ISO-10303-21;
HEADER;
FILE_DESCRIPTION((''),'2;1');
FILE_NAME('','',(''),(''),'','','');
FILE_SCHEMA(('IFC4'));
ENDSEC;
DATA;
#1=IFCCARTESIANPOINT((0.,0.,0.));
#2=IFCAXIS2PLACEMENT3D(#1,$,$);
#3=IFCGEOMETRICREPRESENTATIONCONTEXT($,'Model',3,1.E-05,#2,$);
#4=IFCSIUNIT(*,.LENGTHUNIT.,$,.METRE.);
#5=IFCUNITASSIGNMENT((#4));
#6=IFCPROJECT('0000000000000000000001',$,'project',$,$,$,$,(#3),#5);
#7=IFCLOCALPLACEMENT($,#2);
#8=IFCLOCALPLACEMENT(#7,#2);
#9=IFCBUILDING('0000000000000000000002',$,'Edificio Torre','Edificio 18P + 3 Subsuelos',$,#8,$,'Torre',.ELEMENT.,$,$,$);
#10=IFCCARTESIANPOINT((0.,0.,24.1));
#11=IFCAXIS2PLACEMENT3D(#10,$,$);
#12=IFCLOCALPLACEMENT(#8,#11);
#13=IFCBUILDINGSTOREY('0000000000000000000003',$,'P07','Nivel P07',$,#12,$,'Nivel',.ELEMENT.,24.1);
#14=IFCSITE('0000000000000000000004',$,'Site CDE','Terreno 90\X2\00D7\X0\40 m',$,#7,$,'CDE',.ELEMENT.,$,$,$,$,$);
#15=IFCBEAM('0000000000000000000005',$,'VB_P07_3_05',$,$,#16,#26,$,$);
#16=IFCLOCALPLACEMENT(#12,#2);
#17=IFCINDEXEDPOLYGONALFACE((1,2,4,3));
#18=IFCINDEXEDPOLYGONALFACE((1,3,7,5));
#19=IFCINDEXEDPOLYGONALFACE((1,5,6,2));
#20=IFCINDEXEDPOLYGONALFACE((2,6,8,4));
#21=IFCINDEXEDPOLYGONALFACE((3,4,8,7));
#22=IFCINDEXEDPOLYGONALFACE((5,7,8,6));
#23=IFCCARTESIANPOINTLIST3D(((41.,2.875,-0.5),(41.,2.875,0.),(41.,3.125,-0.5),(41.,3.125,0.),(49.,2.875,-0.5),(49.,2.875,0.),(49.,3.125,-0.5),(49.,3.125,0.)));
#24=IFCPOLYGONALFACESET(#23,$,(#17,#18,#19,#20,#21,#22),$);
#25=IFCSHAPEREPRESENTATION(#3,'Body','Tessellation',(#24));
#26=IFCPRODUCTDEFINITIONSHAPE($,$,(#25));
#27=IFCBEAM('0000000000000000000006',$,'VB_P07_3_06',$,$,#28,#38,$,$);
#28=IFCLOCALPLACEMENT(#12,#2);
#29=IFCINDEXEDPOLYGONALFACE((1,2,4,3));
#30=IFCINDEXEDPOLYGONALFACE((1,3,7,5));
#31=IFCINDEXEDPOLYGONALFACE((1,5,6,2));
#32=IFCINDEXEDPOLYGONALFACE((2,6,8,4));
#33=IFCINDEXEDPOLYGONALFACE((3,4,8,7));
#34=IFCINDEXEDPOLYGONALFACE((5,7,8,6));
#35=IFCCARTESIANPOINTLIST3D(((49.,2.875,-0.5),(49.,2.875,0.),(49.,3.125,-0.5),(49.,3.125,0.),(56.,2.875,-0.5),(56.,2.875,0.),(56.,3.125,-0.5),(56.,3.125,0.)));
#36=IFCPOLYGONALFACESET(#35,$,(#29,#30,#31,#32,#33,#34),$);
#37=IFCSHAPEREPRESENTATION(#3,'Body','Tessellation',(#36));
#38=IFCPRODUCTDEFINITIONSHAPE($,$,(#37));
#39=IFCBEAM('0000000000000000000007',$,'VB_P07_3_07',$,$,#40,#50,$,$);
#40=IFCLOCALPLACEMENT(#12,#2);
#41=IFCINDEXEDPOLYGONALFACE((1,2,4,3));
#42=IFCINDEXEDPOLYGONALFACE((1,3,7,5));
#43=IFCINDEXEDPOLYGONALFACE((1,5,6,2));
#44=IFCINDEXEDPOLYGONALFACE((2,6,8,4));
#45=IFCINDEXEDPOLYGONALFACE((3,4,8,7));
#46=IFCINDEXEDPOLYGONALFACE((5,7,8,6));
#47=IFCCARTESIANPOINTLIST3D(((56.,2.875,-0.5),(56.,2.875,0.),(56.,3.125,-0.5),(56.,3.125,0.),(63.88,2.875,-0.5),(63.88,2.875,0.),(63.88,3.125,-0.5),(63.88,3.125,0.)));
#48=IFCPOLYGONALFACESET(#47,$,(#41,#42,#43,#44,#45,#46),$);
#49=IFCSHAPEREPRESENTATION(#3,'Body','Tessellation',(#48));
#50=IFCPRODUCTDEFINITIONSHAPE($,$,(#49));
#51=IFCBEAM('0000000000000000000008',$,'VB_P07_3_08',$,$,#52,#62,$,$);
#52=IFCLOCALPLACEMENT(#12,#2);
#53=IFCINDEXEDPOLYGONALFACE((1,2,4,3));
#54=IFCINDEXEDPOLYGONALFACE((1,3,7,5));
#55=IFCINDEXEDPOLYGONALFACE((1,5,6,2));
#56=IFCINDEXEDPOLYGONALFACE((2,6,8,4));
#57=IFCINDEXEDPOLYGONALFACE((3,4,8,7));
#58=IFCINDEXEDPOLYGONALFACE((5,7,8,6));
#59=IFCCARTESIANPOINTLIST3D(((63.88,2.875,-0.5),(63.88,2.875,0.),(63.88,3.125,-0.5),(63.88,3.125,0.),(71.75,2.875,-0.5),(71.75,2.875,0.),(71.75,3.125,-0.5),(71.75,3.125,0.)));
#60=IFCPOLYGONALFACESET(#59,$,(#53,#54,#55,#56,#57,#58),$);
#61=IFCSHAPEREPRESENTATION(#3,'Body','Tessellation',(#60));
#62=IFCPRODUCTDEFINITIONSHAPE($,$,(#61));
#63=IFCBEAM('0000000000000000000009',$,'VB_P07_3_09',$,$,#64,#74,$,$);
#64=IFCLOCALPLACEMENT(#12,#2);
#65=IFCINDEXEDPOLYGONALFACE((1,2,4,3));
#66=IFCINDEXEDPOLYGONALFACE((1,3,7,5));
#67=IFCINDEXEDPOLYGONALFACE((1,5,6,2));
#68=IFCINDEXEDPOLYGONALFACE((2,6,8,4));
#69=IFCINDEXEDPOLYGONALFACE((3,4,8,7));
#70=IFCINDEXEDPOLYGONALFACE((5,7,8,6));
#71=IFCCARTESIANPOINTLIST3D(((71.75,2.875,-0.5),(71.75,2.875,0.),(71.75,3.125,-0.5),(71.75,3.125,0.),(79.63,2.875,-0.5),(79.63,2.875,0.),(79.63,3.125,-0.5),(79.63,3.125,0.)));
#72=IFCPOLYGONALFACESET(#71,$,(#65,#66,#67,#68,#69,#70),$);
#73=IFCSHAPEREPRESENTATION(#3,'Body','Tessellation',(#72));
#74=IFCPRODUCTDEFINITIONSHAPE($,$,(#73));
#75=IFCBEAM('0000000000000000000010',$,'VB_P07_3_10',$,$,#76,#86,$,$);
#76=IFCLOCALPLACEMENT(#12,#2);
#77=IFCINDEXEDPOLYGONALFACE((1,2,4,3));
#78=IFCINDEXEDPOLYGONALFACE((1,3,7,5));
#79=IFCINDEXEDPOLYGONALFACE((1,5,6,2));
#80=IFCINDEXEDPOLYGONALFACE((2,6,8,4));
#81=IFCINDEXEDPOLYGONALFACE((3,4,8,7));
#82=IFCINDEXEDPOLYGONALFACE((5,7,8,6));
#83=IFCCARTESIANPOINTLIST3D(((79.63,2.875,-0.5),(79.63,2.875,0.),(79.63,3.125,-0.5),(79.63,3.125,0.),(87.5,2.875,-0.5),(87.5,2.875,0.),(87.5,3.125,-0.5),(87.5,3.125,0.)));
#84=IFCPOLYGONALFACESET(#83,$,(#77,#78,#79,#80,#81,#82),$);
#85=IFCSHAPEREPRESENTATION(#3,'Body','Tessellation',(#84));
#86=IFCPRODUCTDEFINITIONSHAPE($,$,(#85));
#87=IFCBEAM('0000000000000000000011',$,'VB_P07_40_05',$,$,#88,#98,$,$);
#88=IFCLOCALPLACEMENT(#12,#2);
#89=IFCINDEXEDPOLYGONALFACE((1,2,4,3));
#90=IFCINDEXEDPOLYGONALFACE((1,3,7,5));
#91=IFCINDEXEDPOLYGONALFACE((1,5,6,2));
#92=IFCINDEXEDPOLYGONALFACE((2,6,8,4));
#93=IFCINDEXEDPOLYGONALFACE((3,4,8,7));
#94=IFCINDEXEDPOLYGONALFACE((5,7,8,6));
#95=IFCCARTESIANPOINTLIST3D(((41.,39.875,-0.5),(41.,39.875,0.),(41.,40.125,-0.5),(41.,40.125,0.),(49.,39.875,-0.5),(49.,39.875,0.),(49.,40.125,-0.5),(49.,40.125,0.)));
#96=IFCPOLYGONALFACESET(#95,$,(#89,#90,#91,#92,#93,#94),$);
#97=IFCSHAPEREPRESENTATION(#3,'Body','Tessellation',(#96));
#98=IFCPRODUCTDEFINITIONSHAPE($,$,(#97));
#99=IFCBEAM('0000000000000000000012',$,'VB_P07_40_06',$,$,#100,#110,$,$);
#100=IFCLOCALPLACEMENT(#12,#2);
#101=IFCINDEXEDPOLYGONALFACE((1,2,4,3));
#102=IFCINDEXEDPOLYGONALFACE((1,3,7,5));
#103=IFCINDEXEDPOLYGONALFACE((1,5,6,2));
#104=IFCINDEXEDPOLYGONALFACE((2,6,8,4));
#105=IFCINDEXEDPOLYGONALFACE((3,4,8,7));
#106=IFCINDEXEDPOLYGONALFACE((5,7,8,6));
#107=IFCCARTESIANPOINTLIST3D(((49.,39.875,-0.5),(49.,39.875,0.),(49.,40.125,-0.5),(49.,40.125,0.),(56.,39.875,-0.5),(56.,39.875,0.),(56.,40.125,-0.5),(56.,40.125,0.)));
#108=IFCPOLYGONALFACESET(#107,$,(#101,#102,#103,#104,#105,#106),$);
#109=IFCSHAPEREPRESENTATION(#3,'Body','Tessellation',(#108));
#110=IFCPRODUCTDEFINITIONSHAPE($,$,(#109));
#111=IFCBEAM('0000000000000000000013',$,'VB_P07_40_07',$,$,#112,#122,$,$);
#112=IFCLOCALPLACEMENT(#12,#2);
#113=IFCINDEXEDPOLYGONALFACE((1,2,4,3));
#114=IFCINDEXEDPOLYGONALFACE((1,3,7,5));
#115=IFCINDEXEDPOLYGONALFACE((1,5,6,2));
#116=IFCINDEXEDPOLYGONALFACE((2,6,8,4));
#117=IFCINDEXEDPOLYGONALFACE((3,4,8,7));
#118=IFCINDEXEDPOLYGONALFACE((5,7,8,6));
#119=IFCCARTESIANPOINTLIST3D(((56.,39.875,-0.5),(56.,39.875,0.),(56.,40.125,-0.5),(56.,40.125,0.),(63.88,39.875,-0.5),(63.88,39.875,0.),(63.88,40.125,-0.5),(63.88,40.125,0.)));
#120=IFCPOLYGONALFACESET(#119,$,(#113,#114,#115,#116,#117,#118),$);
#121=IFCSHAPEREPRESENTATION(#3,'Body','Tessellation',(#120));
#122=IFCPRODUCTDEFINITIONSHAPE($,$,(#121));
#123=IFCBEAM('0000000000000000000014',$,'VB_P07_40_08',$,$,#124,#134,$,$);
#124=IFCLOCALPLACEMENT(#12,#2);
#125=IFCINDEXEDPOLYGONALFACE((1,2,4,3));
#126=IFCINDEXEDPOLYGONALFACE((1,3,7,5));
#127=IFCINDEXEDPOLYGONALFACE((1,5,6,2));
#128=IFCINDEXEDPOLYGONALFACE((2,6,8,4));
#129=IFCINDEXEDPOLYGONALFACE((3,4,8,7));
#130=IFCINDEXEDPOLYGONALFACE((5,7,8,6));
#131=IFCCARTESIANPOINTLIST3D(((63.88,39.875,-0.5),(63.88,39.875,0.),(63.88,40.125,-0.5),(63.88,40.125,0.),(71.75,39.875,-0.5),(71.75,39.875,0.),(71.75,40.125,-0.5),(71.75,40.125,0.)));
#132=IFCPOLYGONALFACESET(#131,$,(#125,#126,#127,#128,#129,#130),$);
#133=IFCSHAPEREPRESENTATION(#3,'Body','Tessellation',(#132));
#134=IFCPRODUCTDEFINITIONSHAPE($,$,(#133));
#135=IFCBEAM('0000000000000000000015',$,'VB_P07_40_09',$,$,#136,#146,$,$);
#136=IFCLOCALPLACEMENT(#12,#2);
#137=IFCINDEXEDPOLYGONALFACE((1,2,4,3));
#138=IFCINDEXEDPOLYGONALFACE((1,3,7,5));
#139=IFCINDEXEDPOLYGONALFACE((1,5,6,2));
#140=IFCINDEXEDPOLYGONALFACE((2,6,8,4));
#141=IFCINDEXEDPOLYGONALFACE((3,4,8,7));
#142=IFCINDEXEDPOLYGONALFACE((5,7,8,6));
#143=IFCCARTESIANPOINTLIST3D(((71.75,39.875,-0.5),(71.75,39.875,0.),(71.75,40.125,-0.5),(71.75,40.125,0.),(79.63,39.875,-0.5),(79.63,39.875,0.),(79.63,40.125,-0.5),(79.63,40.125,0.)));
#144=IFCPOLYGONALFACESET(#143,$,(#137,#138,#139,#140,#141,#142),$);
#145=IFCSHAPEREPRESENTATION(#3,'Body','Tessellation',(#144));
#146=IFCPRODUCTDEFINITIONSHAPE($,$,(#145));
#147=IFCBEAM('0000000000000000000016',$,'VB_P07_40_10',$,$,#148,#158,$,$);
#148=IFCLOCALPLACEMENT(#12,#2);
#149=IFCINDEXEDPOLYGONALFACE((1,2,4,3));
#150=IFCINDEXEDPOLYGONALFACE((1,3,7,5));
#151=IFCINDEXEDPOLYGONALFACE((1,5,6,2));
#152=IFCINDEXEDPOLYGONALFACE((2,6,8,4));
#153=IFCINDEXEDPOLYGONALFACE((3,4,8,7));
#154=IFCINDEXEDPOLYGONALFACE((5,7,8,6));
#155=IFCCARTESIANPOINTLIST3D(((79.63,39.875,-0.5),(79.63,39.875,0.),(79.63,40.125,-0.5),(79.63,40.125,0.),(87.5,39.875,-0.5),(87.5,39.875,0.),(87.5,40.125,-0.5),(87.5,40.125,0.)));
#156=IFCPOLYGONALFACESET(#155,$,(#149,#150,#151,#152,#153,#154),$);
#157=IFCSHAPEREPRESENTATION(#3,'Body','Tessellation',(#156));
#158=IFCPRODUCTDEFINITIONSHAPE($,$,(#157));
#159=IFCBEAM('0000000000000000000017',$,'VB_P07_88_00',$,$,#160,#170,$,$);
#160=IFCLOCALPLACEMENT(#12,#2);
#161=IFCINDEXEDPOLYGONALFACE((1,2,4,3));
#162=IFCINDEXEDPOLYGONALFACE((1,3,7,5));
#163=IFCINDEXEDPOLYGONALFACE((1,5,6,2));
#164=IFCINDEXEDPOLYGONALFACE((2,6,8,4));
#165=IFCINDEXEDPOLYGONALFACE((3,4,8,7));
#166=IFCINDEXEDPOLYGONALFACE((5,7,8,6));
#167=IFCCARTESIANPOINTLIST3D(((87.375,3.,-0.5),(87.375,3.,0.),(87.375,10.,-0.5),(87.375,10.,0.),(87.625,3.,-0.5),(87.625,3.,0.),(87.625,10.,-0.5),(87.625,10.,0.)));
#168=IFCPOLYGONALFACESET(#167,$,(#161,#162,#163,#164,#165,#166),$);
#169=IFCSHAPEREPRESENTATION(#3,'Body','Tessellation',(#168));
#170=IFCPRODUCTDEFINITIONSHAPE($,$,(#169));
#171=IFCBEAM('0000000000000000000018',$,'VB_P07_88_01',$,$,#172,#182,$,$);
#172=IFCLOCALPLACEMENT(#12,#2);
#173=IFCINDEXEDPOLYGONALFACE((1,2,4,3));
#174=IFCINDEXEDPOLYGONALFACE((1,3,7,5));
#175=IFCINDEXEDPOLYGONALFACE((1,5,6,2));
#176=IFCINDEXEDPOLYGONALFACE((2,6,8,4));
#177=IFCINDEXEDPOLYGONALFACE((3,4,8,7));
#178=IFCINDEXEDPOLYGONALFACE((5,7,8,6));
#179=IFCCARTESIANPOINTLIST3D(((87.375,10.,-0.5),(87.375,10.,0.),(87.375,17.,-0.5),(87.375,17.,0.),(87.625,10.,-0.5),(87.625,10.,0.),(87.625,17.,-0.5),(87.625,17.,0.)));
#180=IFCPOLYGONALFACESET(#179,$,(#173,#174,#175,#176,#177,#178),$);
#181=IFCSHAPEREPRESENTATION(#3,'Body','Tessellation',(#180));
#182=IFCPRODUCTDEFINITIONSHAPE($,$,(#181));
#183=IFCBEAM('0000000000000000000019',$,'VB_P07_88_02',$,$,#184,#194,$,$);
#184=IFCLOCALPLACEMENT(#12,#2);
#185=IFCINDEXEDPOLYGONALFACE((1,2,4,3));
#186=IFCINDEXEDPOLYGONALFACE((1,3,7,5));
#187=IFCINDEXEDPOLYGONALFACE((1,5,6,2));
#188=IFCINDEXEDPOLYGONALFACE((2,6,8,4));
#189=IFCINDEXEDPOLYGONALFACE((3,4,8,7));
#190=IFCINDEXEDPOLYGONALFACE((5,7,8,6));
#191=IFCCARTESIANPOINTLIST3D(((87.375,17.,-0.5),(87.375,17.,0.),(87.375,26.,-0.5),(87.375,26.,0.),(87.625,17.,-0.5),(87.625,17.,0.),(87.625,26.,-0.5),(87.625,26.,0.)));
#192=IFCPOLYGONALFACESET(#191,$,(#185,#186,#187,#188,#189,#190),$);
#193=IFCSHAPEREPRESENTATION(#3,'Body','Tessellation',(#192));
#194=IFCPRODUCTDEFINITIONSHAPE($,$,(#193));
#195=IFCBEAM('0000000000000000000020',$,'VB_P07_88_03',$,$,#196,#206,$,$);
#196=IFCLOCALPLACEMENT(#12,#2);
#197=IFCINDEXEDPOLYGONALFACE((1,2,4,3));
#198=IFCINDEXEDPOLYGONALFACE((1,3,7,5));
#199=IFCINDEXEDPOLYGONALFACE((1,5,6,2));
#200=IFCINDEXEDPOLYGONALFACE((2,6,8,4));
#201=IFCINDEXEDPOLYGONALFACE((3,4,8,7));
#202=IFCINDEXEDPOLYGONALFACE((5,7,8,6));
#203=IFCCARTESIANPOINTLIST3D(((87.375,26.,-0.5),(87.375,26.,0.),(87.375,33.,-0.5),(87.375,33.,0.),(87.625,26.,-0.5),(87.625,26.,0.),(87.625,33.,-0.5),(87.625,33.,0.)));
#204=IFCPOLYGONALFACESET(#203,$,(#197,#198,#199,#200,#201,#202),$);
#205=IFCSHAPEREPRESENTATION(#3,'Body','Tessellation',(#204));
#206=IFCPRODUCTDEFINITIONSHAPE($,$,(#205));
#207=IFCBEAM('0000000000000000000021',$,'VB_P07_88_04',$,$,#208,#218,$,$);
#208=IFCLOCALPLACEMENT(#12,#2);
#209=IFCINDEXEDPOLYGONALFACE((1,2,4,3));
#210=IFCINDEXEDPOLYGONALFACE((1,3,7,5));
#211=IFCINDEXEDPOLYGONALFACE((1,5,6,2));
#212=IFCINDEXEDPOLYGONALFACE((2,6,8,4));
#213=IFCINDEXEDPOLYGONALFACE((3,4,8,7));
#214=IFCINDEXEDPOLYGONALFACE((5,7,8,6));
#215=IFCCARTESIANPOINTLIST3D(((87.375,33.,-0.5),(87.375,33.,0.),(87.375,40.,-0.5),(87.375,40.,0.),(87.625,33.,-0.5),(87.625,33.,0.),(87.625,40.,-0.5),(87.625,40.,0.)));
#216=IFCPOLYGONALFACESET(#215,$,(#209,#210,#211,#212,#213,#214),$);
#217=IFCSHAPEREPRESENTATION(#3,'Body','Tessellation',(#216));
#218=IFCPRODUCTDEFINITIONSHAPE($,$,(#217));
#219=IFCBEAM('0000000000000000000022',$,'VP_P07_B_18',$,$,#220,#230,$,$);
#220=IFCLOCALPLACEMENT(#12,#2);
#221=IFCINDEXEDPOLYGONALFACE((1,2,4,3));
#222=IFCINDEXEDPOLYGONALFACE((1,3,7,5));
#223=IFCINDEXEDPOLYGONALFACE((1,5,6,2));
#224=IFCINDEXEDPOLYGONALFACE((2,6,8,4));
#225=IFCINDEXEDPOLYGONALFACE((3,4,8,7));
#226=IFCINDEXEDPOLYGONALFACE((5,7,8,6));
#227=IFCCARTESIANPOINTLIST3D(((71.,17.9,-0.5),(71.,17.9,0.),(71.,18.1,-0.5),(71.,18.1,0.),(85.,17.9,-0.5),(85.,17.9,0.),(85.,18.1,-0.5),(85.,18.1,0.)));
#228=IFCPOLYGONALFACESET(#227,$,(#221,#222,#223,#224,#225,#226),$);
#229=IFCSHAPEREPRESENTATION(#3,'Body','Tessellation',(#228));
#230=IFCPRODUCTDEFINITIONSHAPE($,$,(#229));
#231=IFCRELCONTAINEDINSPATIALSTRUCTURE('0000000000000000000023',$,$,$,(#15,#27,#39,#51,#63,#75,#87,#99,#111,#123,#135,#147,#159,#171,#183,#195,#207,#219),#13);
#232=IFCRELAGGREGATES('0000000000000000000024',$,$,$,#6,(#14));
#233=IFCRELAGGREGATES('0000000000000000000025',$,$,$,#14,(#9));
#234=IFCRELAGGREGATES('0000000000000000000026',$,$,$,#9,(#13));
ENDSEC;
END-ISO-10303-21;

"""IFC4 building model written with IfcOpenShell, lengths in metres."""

from ifc_helpers import new_model, si_unit, frame, origin, origin_2d, place, context, project, spatial, rectangle, extrude, element, save


model = new_model("IFC4")

# Units and contexts
model_context = context("Model", 3, precision=1e-05, world=origin())
ifc_project = project(units=[si_unit("LENGTHUNIT", "METRE")], contexts=[model_context])

# Site, building, storey
site_placement = place(None, origin())
site = spatial("IfcSite", under=ifc_project, at=site_placement, Name="Site CDE", Description="Terreno 90×40 m", LongName="CDE", CompositionType="ELEMENT")
building_placement = place(site_placement, origin())
building = spatial("IfcBuilding", under=site, at=building_placement, Name="Edificio Torre", Description="Edificio 18P + 3 Subsuelos", LongName="Torre", CompositionType="ELEMENT")
storey_placement = place(building_placement, frame((0.0, 0.0, 24.1)))
storey = spatial("IfcBuildingStorey", under=building, at=storey_placement, Name="P07", Description="Nivel P07", LongName="Nivel", CompositionType="ELEMENT", Elevation=24.1)

# Beams
beam_1_placement = place(storey_placement, frame((45.0, 3.0, -0.5)))
element("IfcBeam", 1, at=beam_1_placement, inside=storey, Name="VB_P07_3_05", context=model_context, shape_type="SweptSolid", body=[
    extrude(rectangle(XDim=8.0, YDim=0.25, at=origin_2d()), origin(), (0.0, 0.0, 1.0), 0.5),
])
beam_2_placement = place(storey_placement, frame((52.5, 3.0, -0.5)))
element("IfcBeam", 2, at=beam_2_placement, inside=storey, Name="VB_P07_3_06", context=model_context, shape_type="SweptSolid", body=[
    extrude(rectangle(XDim=7.0, YDim=0.25, at=origin_2d()), origin(), (0.0, 0.0, 1.0), 0.5),
])
beam_3_placement = place(storey_placement, frame((59.94, 3.0, -0.5)))
element("IfcBeam", 3, at=beam_3_placement, inside=storey, Name="VB_P07_3_07", context=model_context, shape_type="SweptSolid", body=[
    extrude(rectangle(XDim=7.88, YDim=0.25, at=origin_2d()), origin(), (0.0, 0.0, 1.0), 0.5),
])
beam_4_placement = place(storey_placement, frame((67.815, 3.0, -0.5)))
element("IfcBeam", 4, at=beam_4_placement, inside=storey, Name="VB_P07_3_08", context=model_context, shape_type="SweptSolid", body=[
    extrude(rectangle(XDim=7.87, YDim=0.25, at=origin_2d()), origin(), (0.0, 0.0, 1.0), 0.5),
])
beam_5_placement = place(storey_placement, frame((75.69, 3.0, -0.5)))
element("IfcBeam", 5, at=beam_5_placement, inside=storey, Name="VB_P07_3_09", context=model_context, shape_type="SweptSolid", body=[
    extrude(rectangle(XDim=7.88, YDim=0.25, at=origin_2d()), origin(), (0.0, 0.0, 1.0), 0.5),
])
beam_6_placement = place(storey_placement, frame((83.565, 3.0, -0.5)))
element("IfcBeam", 6, at=beam_6_placement, inside=storey, Name="VB_P07_3_10", context=model_context, shape_type="SweptSolid", body=[
    extrude(rectangle(XDim=7.87, YDim=0.25, at=origin_2d()), origin(), (0.0, 0.0, 1.0), 0.5),
])
beam_7_placement = place(storey_placement, frame((45.0, 40.0, -0.5)))
element("IfcBeam", 7, at=beam_7_placement, inside=storey, Name="VB_P07_40_05", context=model_context, shape_type="SweptSolid", body=[
    extrude(rectangle(XDim=8.0, YDim=0.25, at=origin_2d()), origin(), (0.0, 0.0, 1.0), 0.5),
])
beam_8_placement = place(storey_placement, frame((52.5, 40.0, -0.5)))
element("IfcBeam", 8, at=beam_8_placement, inside=storey, Name="VB_P07_40_06", context=model_context, shape_type="SweptSolid", body=[
    extrude(rectangle(XDim=7.0, YDim=0.25, at=origin_2d()), origin(), (0.0, 0.0, 1.0), 0.5),
])
beam_9_placement = place(storey_placement, frame((59.94, 40.0, -0.5)))
element("IfcBeam", 9, at=beam_9_placement, inside=storey, Name="VB_P07_40_07", context=model_context, shape_type="SweptSolid", body=[
    extrude(rectangle(XDim=7.88, YDim=0.25, at=origin_2d()), origin(), (0.0, 0.0, 1.0), 0.5),
])
beam_10_placement = place(storey_placement, frame((67.815, 40.0, -0.5)))
element("IfcBeam", 10, at=beam_10_placement, inside=storey, Name="VB_P07_40_08", context=model_context, shape_type="SweptSolid", body=[
    extrude(rectangle(XDim=7.87, YDim=0.25, at=origin_2d()), origin(), (0.0, 0.0, 1.0), 0.5),
])
beam_11_placement = place(storey_placement, frame((75.69, 40.0, -0.5)))
element("IfcBeam", 11, at=beam_11_placement, inside=storey, Name="VB_P07_40_09", context=model_context, shape_type="SweptSolid", body=[
    extrude(rectangle(XDim=7.88, YDim=0.25, at=origin_2d()), origin(), (0.0, 0.0, 1.0), 0.5),
])
beam_12_placement = place(storey_placement, frame((83.565, 40.0, -0.5)))
element("IfcBeam", 12, at=beam_12_placement, inside=storey, Name="VB_P07_40_10", context=model_context, shape_type="SweptSolid", body=[
    extrude(rectangle(XDim=7.87, YDim=0.25, at=origin_2d()), origin(), (0.0, 0.0, 1.0), 0.5),
])
for number, where, name in (
    (13, (87.5, 6.5, -0.5), "VB_P07_88_00"),
    (14, (87.5, 13.5, -0.5), "VB_P07_88_01"),
):
    element("IfcBeam", number, at=place(storey_placement, frame(where)), inside=storey, Name=name, context=model_context, shape_type="SweptSolid", body=[
        extrude(rectangle(XDim=0.25, YDim=7.0, at=origin_2d()), origin(), (0.0, 0.0, 1.0), 0.5),
    ])
beam_13_placement = place(storey_placement, frame((87.5, 21.5, -0.5)))
element("IfcBeam", 15, at=beam_13_placement, inside=storey, Name="VB_P07_88_02", context=model_context, shape_type="SweptSolid", body=[
    extrude(rectangle(XDim=0.25, YDim=9.0, at=origin_2d()), origin(), (0.0, 0.0, 1.0), 0.5),
])
for number, where, name in (
    (16, (87.5, 29.5, -0.5), "VB_P07_88_03"),
    (17, (87.5, 36.5, -0.5), "VB_P07_88_04"),
):
    element("IfcBeam", number, at=place(storey_placement, frame(where)), inside=storey, Name=name, context=model_context, shape_type="SweptSolid", body=[
        extrude(rectangle(XDim=0.25, YDim=7.0, at=origin_2d()), origin(), (0.0, 0.0, 1.0), 0.5),
    ])
for number, where, name in (
    (18, (78.0, 18.0, -0.5), "VP_P07_B_18"),
):
    element("IfcBeam", number, at=place(storey_placement, frame(where)), inside=storey, Name=name, context=model_context, shape_type="SweptSolid", body=[
        extrude(rectangle(XDim=14.0, YDim=0.2, at=origin_2d()), origin(), (0.0, 0.0, 1.0), 0.5),
    ])

save(model, "model.ifc")
